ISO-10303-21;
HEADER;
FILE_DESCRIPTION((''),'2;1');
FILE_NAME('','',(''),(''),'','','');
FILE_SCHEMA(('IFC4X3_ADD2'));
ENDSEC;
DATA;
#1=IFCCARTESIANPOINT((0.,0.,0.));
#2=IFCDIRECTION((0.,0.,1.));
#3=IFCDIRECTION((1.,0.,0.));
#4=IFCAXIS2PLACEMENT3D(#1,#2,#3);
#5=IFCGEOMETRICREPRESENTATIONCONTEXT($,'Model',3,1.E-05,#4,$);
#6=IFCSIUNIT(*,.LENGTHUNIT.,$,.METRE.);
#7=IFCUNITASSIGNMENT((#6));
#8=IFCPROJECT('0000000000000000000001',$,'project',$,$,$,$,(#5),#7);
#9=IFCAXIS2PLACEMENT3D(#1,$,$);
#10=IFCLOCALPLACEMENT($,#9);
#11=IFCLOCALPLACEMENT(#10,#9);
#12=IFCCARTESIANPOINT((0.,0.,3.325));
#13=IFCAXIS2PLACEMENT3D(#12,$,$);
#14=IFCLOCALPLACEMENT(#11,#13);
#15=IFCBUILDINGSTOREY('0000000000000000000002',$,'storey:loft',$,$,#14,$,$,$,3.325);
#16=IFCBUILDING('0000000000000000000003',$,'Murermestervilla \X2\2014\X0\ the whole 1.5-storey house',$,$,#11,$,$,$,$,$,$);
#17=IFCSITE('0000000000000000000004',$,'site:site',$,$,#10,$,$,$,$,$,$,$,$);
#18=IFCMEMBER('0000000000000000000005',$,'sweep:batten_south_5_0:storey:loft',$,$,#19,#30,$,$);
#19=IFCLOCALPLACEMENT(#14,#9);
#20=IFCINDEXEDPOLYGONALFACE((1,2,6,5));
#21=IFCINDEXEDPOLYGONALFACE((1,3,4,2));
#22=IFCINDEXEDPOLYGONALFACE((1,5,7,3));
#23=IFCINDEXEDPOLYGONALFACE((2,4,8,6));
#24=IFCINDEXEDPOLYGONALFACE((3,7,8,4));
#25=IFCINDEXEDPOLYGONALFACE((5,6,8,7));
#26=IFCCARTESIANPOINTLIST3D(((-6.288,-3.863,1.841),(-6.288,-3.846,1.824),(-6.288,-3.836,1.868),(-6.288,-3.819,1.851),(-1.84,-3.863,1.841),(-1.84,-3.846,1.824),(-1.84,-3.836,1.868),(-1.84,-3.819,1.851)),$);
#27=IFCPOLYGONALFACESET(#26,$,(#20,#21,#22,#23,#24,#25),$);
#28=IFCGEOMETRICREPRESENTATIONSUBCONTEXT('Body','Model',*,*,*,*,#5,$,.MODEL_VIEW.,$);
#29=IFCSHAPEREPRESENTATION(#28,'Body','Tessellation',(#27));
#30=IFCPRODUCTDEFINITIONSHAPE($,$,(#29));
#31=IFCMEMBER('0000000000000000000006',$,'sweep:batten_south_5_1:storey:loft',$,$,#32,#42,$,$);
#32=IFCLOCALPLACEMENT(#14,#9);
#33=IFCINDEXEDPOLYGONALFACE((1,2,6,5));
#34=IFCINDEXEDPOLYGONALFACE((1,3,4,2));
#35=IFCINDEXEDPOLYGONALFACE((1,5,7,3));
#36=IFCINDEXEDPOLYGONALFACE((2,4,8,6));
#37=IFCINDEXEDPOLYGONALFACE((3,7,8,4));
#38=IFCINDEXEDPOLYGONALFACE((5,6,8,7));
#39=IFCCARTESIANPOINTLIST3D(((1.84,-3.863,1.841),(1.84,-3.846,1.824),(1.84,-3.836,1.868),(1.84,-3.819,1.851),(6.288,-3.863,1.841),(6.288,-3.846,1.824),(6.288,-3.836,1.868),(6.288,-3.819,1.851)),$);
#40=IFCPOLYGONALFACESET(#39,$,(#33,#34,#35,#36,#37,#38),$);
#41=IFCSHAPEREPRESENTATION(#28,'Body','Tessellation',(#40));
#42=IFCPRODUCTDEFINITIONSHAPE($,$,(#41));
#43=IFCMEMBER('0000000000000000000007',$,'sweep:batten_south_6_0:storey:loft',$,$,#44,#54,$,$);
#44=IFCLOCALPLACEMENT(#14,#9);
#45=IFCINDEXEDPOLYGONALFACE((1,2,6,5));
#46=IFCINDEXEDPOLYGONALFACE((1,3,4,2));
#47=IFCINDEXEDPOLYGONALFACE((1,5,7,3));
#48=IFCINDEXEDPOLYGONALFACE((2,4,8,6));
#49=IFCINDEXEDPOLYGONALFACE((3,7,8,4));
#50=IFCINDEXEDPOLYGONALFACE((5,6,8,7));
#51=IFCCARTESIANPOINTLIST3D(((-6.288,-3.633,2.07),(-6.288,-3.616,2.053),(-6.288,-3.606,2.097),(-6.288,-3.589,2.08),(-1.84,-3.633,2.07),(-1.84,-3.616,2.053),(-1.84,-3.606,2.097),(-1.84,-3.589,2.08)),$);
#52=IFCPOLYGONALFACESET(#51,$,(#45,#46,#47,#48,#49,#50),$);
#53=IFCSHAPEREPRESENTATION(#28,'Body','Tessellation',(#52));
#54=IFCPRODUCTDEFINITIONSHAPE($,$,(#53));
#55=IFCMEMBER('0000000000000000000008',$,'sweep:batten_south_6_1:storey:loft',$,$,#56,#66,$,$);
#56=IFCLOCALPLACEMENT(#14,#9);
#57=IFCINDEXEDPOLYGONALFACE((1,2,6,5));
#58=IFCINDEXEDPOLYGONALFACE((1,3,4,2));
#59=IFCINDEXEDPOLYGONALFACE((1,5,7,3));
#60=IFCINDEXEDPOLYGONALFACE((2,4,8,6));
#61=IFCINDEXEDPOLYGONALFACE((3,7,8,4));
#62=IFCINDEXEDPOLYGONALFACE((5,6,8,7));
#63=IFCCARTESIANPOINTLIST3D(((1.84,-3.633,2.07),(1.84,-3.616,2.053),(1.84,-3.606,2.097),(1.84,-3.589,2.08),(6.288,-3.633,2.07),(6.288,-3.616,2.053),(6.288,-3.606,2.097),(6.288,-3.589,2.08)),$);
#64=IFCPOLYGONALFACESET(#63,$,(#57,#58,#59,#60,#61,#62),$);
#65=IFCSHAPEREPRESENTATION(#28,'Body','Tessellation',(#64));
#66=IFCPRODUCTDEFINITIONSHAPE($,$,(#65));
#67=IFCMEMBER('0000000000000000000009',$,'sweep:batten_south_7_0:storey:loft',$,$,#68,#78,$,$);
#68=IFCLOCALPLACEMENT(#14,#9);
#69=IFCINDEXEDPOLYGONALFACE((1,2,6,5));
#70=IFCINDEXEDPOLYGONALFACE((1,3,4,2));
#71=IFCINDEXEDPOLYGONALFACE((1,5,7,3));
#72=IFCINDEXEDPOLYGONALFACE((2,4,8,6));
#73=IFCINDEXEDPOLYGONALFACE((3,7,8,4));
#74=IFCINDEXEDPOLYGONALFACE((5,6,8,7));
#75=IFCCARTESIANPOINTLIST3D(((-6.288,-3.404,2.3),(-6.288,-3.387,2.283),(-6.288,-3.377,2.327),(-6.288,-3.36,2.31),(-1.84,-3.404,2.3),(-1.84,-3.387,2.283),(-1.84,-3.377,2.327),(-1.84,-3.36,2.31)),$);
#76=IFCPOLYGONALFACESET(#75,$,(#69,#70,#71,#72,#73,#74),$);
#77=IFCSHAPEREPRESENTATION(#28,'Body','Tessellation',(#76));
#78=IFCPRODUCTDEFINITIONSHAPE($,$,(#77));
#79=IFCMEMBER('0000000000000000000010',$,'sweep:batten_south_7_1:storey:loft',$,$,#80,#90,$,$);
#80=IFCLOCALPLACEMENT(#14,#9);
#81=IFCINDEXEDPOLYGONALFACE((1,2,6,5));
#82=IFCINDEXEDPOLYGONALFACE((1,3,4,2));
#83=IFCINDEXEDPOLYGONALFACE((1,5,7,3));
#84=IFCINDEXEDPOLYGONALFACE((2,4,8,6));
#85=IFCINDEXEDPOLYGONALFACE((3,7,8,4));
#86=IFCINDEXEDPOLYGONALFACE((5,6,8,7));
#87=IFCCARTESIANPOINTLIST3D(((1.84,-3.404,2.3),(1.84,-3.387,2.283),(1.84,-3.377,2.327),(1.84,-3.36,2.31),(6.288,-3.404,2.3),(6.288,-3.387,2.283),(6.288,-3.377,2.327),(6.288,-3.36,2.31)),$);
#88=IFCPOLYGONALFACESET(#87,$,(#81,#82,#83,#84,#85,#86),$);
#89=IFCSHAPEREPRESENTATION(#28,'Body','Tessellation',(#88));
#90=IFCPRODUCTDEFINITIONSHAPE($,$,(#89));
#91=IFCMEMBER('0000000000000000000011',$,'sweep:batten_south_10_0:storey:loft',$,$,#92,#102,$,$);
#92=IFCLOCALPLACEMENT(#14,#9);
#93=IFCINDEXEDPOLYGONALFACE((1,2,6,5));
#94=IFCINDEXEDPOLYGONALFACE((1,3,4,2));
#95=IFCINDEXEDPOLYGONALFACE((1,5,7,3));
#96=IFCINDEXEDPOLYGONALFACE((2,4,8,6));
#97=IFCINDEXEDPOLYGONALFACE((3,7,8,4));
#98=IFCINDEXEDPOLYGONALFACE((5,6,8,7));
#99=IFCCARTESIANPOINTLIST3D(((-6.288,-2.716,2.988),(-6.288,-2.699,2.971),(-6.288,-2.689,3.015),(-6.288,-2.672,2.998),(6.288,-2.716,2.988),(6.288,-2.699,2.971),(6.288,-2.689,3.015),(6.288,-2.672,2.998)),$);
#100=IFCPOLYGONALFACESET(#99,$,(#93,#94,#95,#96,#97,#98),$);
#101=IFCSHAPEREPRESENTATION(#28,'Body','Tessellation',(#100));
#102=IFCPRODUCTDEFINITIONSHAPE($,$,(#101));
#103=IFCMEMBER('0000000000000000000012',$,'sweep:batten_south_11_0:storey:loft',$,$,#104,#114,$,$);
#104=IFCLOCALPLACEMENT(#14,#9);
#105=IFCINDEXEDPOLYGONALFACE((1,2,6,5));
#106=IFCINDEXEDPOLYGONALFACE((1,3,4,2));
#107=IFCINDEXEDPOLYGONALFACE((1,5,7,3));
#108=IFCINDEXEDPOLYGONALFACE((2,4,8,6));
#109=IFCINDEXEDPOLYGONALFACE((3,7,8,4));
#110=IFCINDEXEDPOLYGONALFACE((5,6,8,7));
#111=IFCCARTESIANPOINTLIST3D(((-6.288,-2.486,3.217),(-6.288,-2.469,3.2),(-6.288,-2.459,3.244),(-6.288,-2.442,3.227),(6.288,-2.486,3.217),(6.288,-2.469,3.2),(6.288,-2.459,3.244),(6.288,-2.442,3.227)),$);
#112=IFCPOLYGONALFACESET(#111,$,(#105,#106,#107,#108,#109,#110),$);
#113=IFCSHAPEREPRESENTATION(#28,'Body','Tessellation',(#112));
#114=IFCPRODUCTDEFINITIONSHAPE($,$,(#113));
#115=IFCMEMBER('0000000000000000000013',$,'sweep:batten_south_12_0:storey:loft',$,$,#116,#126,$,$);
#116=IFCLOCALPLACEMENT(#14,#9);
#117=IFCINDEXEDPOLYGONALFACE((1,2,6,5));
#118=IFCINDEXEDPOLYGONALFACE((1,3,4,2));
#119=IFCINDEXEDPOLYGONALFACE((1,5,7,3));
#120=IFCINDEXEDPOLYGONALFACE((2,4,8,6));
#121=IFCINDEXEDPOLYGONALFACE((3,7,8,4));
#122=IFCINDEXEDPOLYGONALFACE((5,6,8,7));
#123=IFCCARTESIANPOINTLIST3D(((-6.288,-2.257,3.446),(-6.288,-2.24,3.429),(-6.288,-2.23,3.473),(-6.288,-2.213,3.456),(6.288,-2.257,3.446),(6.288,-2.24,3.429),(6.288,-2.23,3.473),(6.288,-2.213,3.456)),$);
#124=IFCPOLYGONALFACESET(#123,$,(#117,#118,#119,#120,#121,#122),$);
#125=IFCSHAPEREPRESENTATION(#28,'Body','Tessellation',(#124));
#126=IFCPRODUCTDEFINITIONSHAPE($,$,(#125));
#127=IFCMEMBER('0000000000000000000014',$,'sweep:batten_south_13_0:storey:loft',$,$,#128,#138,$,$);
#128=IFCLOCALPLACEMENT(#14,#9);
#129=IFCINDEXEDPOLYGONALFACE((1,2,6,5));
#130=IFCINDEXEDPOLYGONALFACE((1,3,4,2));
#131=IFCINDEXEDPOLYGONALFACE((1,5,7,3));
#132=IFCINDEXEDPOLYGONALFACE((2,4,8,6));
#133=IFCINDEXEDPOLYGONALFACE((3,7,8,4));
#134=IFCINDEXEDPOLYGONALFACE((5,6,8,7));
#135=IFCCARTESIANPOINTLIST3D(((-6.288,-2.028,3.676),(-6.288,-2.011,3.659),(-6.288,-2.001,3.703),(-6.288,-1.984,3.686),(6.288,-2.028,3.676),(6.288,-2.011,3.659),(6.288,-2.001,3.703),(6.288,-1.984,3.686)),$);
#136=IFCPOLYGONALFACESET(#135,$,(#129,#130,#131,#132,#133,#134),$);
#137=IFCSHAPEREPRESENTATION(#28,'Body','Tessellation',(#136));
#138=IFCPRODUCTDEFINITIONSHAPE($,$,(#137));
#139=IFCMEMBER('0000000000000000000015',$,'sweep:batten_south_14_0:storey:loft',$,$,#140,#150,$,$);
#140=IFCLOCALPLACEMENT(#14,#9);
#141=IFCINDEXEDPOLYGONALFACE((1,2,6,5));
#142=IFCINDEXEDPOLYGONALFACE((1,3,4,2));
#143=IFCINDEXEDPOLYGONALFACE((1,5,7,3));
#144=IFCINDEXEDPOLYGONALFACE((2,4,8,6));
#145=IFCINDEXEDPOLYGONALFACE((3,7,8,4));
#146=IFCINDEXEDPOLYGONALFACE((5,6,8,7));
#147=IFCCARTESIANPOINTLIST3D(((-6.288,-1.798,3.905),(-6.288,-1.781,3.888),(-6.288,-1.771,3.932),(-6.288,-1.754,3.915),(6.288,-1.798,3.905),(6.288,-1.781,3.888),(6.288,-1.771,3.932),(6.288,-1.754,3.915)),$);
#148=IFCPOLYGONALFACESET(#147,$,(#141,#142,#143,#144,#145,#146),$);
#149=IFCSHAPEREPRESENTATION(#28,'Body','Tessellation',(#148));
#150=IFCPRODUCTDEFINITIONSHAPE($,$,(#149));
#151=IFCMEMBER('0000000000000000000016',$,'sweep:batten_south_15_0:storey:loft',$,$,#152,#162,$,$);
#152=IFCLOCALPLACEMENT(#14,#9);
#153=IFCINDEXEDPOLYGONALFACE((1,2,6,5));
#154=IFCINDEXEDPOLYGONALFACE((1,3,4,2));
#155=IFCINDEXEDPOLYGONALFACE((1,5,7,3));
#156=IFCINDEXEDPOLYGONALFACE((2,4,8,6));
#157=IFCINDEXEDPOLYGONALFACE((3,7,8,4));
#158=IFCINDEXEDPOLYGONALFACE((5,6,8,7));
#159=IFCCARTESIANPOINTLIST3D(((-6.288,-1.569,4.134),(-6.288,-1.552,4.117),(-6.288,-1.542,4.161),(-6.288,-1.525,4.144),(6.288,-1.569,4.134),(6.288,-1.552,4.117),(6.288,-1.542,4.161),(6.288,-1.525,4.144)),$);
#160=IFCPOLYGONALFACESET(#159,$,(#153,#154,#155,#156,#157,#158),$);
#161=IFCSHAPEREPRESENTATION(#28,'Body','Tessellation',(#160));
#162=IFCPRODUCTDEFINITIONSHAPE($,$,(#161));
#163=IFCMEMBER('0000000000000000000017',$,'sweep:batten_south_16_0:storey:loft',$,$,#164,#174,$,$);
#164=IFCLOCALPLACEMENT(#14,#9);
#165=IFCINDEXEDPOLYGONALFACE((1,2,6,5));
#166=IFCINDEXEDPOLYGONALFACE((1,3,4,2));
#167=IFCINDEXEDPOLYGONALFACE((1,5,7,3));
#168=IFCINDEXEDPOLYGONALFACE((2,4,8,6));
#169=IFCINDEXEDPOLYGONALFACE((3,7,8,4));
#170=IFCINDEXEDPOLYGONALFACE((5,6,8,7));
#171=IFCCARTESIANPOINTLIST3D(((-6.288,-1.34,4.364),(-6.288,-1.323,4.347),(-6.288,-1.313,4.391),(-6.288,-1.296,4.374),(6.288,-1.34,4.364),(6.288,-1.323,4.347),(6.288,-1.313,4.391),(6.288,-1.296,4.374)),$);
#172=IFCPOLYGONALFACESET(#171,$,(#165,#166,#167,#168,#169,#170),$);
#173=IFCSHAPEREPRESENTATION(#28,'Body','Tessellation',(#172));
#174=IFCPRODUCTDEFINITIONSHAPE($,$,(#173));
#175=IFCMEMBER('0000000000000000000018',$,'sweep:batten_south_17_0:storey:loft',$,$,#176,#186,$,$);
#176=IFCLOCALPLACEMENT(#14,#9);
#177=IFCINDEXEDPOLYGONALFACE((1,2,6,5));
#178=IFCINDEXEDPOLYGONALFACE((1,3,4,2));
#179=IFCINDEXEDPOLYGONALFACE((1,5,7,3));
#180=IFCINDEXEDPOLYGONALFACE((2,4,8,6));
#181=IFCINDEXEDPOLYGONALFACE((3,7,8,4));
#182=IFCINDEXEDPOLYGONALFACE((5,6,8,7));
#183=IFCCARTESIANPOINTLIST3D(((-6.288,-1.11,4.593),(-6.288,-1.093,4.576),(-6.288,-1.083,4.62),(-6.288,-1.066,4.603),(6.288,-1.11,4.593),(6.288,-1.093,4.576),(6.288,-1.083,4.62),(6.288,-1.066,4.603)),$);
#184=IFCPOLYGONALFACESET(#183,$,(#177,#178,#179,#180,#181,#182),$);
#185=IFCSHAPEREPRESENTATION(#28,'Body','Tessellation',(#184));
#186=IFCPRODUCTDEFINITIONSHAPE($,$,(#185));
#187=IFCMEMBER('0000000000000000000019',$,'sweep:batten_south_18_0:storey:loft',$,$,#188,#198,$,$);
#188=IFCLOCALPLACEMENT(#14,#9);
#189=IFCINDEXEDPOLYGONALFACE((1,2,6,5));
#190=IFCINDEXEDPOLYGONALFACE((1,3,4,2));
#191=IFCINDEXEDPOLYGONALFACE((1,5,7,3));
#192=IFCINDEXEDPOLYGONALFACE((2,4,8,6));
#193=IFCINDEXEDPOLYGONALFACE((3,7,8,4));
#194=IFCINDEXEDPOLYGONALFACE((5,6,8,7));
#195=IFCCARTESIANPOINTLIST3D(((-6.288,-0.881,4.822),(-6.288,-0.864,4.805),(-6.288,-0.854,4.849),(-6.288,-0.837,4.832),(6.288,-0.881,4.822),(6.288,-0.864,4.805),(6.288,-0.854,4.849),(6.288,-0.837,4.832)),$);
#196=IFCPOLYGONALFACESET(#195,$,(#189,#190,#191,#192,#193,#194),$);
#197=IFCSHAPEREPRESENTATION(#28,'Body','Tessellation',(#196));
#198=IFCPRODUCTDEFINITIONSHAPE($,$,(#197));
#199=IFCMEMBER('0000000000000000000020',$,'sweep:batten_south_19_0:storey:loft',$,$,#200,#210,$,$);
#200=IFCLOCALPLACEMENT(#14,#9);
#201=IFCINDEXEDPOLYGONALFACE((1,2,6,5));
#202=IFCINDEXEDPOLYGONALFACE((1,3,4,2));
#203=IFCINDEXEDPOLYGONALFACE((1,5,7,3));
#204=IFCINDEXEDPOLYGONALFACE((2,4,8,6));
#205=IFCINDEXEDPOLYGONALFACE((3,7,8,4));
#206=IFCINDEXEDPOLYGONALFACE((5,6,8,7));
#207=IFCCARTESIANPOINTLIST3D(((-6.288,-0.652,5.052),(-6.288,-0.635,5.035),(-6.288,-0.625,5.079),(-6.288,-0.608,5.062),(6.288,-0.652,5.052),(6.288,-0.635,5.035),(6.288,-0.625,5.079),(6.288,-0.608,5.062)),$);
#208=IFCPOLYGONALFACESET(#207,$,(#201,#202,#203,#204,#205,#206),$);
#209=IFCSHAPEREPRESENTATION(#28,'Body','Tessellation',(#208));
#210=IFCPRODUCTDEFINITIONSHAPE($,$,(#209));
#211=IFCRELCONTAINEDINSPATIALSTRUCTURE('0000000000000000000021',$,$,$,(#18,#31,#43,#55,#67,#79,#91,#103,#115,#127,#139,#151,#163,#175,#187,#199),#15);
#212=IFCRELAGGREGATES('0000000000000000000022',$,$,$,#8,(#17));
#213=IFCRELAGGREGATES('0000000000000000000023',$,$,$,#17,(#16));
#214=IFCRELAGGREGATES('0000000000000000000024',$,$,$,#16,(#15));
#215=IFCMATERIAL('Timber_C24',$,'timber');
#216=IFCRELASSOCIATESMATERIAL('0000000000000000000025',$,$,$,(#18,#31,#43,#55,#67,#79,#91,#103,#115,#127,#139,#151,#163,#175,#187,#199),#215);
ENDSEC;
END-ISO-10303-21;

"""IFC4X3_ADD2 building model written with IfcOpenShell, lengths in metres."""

from ifc_helpers import new_model, si_unit, frame, origin, origin_with_axes, place, context, subcontext, project, spatial, polyline, outline, extrude, material, element, save


model = new_model("IFC4X3_ADD2")

# Units and contexts
model_context = context("Model", 3, precision=1e-05, world=origin_with_axes())
body_context = subcontext(model_context, "Body", "Model", "MODEL_VIEW")
ifc_project = project(units=[si_unit("LENGTHUNIT", "METRE")], contexts=[model_context])

# Site, building, storey
site_placement = place(None, origin())
site = spatial("IfcSite", under=ifc_project, at=site_placement, Name="site:site")
building_placement = place(site_placement, origin())
building = spatial("IfcBuilding", under=site, at=building_placement, Name="Murermestervilla — the whole 1.5-storey house")
storey_placement = place(building_placement, frame((0.0, 0.0, 3.325)))
storey = spatial("IfcBuildingStorey", under=building, at=storey_placement, Name="storey:loft", Elevation=3.325)

# Members
ifc_material = material(Name="Timber_C24", Category="timber")
placement = place(storey_placement, frame((0.0, 0.0, -3.325)))
element("IfcMember", 1, at=placement, inside=storey, material=ifc_material, Name="sweep:batten_south_5_0:storey:loft", context=body_context, shape_type="SweptSolid", body=[
    extrude(outline(polyline([(-0.005, -0.022), (0.022, 0.005), (0.005, 0.022), (-0.022, -0.005), (-0.005, -0.022)])), frame((-6.288, -3.841, 5.171), z_axis=(1.0, 0.0, 0.0), x_axis=(0.0, 1.0, 0.0)), (0.0, 0.0, 1.0), 4.448),
])
element("IfcMember", 2, at=placement, inside=storey, material=ifc_material, Name="sweep:batten_south_5_1:storey:loft", context=body_context, shape_type="SweptSolid", body=[
    extrude(outline(polyline([(-0.005, -0.022), (0.022, 0.005), (0.005, 0.022), (-0.022, -0.005), (-0.005, -0.022)])), frame((1.84, -3.841, 5.171), z_axis=(1.0, 0.0, 0.0), x_axis=(0.0, 1.0, 0.0)), (0.0, 0.0, 1.0), 4.448),
])
element("IfcMember", 3, at=placement, inside=storey, material=ifc_material, Name="sweep:batten_south_6_0:storey:loft", context=body_context, shape_type="SweptSolid", body=[
    extrude(outline(polyline([(-0.005, -0.022), (0.022, 0.005), (0.005, 0.022), (-0.022, -0.005), (-0.005, -0.022)])), frame((-6.288, -3.611, 5.4), z_axis=(1.0, 0.0, 0.0), x_axis=(0.0, 1.0, 0.0)), (0.0, 0.0, 1.0), 4.448),
])
element("IfcMember", 4, at=placement, inside=storey, material=ifc_material, Name="sweep:batten_south_6_1:storey:loft", context=body_context, shape_type="SweptSolid", body=[
    extrude(outline(polyline([(-0.005, -0.022), (0.022, 0.005), (0.005, 0.022), (-0.022, -0.005), (-0.005, -0.022)])), frame((1.84, -3.611, 5.4), z_axis=(1.0, 0.0, 0.0), x_axis=(0.0, 1.0, 0.0)), (0.0, 0.0, 1.0), 4.448),
])
element("IfcMember", 5, at=placement, inside=storey, material=ifc_material, Name="sweep:batten_south_7_0:storey:loft", context=body_context, shape_type="SweptSolid", body=[
    extrude(outline(polyline([(-0.005, -0.022), (0.022, 0.005), (0.005, 0.022), (-0.022, -0.005), (-0.005, -0.022)])), frame((-6.288, -3.382, 5.63), z_axis=(1.0, 0.0, 0.0), x_axis=(0.0, 1.0, 0.0)), (0.0, 0.0, 1.0), 4.448),
])
element("IfcMember", 6, at=placement, inside=storey, material=ifc_material, Name="sweep:batten_south_7_1:storey:loft", context=body_context, shape_type="SweptSolid", body=[
    extrude(outline(polyline([(-0.005, -0.022), (0.022, 0.005), (0.005, 0.022), (-0.022, -0.005), (-0.005, -0.022)])), frame((1.84, -3.382, 5.63), z_axis=(1.0, 0.0, 0.0), x_axis=(0.0, 1.0, 0.0)), (0.0, 0.0, 1.0), 4.448),
])
element("IfcMember", 7, at=placement, inside=storey, material=ifc_material, Name="sweep:batten_south_10_0:storey:loft", context=body_context, shape_type="SweptSolid", body=[
    extrude(outline(polyline([(-0.005, -0.022), (0.022, 0.005), (0.005, 0.022), (-0.022, -0.005), (-0.005, -0.022)])), frame((-6.288, -2.694, 6.318), z_axis=(1.0, 0.0, 0.0), x_axis=(0.0, 1.0, 0.0)), (0.0, 0.0, 1.0), 12.576),
])
element("IfcMember", 8, at=placement, inside=storey, material=ifc_material, Name="sweep:batten_south_11_0:storey:loft", context=body_context, shape_type="SweptSolid", body=[
    extrude(outline(polyline([(-0.005, -0.022), (0.022, 0.005), (0.005, 0.022), (-0.022, -0.005), (-0.005, -0.022)])), frame((-6.288, -2.464, 6.547), z_axis=(1.0, 0.0, 0.0), x_axis=(0.0, 1.0, 0.0)), (0.0, 0.0, 1.0), 12.576),
])
element("IfcMember", 9, at=placement, inside=storey, material=ifc_material, Name="sweep:batten_south_12_0:storey:loft", context=body_context, shape_type="SweptSolid", body=[
    extrude(outline(polyline([(-0.005, -0.022), (0.022, 0.005), (0.005, 0.022), (-0.022, -0.005), (-0.005, -0.022)])), frame((-6.288, -2.235, 6.776), z_axis=(1.0, 0.0, 0.0), x_axis=(0.0, 1.0, 0.0)), (0.0, 0.0, 1.0), 12.576),
])
element("IfcMember", 10, at=placement, inside=storey, material=ifc_material, Name="sweep:batten_south_13_0:storey:loft", context=body_context, shape_type="SweptSolid", body=[
    extrude(outline(polyline([(-0.005, -0.022), (0.022, 0.005), (0.005, 0.022), (-0.022, -0.005), (-0.005, -0.022)])), frame((-6.288, -2.006, 7.006), z_axis=(1.0, 0.0, 0.0), x_axis=(0.0, 1.0, 0.0)), (0.0, 0.0, 1.0), 12.576),
])
element("IfcMember", 11, at=placement, inside=storey, material=ifc_material, Name="sweep:batten_south_14_0:storey:loft", context=body_context, shape_type="SweptSolid", body=[
    extrude(outline(polyline([(-0.005, -0.022), (0.022, 0.005), (0.005, 0.022), (-0.022, -0.005), (-0.005, -0.022)])), frame((-6.288, -1.776, 7.235), z_axis=(1.0, 0.0, 0.0), x_axis=(0.0, 1.0, 0.0)), (0.0, 0.0, 1.0), 12.576),
])
element("IfcMember", 12, at=placement, inside=storey, material=ifc_material, Name="sweep:batten_south_15_0:storey:loft", context=body_context, shape_type="SweptSolid", body=[
    extrude(outline(polyline([(-0.005, -0.022), (0.022, 0.005), (0.005, 0.022), (-0.022, -0.005), (-0.005, -0.022)])), frame((-6.288, -1.547, 7.464), z_axis=(1.0, 0.0, 0.0), x_axis=(0.0, 1.0, 0.0)), (0.0, 0.0, 1.0), 12.576),
])
element("IfcMember", 13, at=placement, inside=storey, material=ifc_material, Name="sweep:batten_south_16_0:storey:loft", context=body_context, shape_type="SweptSolid", body=[
    extrude(outline(polyline([(-0.005, -0.022), (0.022, 0.005), (0.005, 0.022), (-0.022, -0.005), (-0.005, -0.022)])), frame((-6.288, -1.318, 7.694), z_axis=(1.0, 0.0, 0.0), x_axis=(0.0, 1.0, 0.0)), (0.0, 0.0, 1.0), 12.576),
])
element("IfcMember", 14, at=placement, inside=storey, material=ifc_material, Name="sweep:batten_south_17_0:storey:loft", context=body_context, shape_type="SweptSolid", body=[
    extrude(outline(polyline([(-0.005, -0.022), (0.022, 0.005), (0.005, 0.022), (-0.022, -0.005), (-0.005, -0.022)])), frame((-6.288, -1.088, 7.923), z_axis=(1.0, 0.0, 0.0), x_axis=(0.0, 1.0, 0.0)), (0.0, 0.0, 1.0), 12.576),
])
element("IfcMember", 15, at=placement, inside=storey, material=ifc_material, Name="sweep:batten_south_18_0:storey:loft", context=body_context, shape_type="SweptSolid", body=[
    extrude(outline(polyline([(-0.005, -0.022), (0.022, 0.005), (0.005, 0.022), (-0.022, -0.005), (-0.005, -0.022)])), frame((-6.288, -0.859, 8.152), z_axis=(1.0, 0.0, 0.0), x_axis=(0.0, 1.0, 0.0)), (0.0, 0.0, 1.0), 12.576),
])
element("IfcMember", 16, at=placement, inside=storey, material=ifc_material, Name="sweep:batten_south_19_0:storey:loft", context=body_context, shape_type="SweptSolid", body=[
    extrude(outline(polyline([(-0.005, -0.022), (0.022, 0.005), (0.005, 0.022), (-0.022, -0.005), (-0.005, -0.022)])), frame((-6.288, -0.63, 8.382), z_axis=(1.0, 0.0, 0.0), x_axis=(0.0, 1.0, 0.0)), (0.0, 0.0, 1.0), 12.576),
])

save(model, "model.ifc")
